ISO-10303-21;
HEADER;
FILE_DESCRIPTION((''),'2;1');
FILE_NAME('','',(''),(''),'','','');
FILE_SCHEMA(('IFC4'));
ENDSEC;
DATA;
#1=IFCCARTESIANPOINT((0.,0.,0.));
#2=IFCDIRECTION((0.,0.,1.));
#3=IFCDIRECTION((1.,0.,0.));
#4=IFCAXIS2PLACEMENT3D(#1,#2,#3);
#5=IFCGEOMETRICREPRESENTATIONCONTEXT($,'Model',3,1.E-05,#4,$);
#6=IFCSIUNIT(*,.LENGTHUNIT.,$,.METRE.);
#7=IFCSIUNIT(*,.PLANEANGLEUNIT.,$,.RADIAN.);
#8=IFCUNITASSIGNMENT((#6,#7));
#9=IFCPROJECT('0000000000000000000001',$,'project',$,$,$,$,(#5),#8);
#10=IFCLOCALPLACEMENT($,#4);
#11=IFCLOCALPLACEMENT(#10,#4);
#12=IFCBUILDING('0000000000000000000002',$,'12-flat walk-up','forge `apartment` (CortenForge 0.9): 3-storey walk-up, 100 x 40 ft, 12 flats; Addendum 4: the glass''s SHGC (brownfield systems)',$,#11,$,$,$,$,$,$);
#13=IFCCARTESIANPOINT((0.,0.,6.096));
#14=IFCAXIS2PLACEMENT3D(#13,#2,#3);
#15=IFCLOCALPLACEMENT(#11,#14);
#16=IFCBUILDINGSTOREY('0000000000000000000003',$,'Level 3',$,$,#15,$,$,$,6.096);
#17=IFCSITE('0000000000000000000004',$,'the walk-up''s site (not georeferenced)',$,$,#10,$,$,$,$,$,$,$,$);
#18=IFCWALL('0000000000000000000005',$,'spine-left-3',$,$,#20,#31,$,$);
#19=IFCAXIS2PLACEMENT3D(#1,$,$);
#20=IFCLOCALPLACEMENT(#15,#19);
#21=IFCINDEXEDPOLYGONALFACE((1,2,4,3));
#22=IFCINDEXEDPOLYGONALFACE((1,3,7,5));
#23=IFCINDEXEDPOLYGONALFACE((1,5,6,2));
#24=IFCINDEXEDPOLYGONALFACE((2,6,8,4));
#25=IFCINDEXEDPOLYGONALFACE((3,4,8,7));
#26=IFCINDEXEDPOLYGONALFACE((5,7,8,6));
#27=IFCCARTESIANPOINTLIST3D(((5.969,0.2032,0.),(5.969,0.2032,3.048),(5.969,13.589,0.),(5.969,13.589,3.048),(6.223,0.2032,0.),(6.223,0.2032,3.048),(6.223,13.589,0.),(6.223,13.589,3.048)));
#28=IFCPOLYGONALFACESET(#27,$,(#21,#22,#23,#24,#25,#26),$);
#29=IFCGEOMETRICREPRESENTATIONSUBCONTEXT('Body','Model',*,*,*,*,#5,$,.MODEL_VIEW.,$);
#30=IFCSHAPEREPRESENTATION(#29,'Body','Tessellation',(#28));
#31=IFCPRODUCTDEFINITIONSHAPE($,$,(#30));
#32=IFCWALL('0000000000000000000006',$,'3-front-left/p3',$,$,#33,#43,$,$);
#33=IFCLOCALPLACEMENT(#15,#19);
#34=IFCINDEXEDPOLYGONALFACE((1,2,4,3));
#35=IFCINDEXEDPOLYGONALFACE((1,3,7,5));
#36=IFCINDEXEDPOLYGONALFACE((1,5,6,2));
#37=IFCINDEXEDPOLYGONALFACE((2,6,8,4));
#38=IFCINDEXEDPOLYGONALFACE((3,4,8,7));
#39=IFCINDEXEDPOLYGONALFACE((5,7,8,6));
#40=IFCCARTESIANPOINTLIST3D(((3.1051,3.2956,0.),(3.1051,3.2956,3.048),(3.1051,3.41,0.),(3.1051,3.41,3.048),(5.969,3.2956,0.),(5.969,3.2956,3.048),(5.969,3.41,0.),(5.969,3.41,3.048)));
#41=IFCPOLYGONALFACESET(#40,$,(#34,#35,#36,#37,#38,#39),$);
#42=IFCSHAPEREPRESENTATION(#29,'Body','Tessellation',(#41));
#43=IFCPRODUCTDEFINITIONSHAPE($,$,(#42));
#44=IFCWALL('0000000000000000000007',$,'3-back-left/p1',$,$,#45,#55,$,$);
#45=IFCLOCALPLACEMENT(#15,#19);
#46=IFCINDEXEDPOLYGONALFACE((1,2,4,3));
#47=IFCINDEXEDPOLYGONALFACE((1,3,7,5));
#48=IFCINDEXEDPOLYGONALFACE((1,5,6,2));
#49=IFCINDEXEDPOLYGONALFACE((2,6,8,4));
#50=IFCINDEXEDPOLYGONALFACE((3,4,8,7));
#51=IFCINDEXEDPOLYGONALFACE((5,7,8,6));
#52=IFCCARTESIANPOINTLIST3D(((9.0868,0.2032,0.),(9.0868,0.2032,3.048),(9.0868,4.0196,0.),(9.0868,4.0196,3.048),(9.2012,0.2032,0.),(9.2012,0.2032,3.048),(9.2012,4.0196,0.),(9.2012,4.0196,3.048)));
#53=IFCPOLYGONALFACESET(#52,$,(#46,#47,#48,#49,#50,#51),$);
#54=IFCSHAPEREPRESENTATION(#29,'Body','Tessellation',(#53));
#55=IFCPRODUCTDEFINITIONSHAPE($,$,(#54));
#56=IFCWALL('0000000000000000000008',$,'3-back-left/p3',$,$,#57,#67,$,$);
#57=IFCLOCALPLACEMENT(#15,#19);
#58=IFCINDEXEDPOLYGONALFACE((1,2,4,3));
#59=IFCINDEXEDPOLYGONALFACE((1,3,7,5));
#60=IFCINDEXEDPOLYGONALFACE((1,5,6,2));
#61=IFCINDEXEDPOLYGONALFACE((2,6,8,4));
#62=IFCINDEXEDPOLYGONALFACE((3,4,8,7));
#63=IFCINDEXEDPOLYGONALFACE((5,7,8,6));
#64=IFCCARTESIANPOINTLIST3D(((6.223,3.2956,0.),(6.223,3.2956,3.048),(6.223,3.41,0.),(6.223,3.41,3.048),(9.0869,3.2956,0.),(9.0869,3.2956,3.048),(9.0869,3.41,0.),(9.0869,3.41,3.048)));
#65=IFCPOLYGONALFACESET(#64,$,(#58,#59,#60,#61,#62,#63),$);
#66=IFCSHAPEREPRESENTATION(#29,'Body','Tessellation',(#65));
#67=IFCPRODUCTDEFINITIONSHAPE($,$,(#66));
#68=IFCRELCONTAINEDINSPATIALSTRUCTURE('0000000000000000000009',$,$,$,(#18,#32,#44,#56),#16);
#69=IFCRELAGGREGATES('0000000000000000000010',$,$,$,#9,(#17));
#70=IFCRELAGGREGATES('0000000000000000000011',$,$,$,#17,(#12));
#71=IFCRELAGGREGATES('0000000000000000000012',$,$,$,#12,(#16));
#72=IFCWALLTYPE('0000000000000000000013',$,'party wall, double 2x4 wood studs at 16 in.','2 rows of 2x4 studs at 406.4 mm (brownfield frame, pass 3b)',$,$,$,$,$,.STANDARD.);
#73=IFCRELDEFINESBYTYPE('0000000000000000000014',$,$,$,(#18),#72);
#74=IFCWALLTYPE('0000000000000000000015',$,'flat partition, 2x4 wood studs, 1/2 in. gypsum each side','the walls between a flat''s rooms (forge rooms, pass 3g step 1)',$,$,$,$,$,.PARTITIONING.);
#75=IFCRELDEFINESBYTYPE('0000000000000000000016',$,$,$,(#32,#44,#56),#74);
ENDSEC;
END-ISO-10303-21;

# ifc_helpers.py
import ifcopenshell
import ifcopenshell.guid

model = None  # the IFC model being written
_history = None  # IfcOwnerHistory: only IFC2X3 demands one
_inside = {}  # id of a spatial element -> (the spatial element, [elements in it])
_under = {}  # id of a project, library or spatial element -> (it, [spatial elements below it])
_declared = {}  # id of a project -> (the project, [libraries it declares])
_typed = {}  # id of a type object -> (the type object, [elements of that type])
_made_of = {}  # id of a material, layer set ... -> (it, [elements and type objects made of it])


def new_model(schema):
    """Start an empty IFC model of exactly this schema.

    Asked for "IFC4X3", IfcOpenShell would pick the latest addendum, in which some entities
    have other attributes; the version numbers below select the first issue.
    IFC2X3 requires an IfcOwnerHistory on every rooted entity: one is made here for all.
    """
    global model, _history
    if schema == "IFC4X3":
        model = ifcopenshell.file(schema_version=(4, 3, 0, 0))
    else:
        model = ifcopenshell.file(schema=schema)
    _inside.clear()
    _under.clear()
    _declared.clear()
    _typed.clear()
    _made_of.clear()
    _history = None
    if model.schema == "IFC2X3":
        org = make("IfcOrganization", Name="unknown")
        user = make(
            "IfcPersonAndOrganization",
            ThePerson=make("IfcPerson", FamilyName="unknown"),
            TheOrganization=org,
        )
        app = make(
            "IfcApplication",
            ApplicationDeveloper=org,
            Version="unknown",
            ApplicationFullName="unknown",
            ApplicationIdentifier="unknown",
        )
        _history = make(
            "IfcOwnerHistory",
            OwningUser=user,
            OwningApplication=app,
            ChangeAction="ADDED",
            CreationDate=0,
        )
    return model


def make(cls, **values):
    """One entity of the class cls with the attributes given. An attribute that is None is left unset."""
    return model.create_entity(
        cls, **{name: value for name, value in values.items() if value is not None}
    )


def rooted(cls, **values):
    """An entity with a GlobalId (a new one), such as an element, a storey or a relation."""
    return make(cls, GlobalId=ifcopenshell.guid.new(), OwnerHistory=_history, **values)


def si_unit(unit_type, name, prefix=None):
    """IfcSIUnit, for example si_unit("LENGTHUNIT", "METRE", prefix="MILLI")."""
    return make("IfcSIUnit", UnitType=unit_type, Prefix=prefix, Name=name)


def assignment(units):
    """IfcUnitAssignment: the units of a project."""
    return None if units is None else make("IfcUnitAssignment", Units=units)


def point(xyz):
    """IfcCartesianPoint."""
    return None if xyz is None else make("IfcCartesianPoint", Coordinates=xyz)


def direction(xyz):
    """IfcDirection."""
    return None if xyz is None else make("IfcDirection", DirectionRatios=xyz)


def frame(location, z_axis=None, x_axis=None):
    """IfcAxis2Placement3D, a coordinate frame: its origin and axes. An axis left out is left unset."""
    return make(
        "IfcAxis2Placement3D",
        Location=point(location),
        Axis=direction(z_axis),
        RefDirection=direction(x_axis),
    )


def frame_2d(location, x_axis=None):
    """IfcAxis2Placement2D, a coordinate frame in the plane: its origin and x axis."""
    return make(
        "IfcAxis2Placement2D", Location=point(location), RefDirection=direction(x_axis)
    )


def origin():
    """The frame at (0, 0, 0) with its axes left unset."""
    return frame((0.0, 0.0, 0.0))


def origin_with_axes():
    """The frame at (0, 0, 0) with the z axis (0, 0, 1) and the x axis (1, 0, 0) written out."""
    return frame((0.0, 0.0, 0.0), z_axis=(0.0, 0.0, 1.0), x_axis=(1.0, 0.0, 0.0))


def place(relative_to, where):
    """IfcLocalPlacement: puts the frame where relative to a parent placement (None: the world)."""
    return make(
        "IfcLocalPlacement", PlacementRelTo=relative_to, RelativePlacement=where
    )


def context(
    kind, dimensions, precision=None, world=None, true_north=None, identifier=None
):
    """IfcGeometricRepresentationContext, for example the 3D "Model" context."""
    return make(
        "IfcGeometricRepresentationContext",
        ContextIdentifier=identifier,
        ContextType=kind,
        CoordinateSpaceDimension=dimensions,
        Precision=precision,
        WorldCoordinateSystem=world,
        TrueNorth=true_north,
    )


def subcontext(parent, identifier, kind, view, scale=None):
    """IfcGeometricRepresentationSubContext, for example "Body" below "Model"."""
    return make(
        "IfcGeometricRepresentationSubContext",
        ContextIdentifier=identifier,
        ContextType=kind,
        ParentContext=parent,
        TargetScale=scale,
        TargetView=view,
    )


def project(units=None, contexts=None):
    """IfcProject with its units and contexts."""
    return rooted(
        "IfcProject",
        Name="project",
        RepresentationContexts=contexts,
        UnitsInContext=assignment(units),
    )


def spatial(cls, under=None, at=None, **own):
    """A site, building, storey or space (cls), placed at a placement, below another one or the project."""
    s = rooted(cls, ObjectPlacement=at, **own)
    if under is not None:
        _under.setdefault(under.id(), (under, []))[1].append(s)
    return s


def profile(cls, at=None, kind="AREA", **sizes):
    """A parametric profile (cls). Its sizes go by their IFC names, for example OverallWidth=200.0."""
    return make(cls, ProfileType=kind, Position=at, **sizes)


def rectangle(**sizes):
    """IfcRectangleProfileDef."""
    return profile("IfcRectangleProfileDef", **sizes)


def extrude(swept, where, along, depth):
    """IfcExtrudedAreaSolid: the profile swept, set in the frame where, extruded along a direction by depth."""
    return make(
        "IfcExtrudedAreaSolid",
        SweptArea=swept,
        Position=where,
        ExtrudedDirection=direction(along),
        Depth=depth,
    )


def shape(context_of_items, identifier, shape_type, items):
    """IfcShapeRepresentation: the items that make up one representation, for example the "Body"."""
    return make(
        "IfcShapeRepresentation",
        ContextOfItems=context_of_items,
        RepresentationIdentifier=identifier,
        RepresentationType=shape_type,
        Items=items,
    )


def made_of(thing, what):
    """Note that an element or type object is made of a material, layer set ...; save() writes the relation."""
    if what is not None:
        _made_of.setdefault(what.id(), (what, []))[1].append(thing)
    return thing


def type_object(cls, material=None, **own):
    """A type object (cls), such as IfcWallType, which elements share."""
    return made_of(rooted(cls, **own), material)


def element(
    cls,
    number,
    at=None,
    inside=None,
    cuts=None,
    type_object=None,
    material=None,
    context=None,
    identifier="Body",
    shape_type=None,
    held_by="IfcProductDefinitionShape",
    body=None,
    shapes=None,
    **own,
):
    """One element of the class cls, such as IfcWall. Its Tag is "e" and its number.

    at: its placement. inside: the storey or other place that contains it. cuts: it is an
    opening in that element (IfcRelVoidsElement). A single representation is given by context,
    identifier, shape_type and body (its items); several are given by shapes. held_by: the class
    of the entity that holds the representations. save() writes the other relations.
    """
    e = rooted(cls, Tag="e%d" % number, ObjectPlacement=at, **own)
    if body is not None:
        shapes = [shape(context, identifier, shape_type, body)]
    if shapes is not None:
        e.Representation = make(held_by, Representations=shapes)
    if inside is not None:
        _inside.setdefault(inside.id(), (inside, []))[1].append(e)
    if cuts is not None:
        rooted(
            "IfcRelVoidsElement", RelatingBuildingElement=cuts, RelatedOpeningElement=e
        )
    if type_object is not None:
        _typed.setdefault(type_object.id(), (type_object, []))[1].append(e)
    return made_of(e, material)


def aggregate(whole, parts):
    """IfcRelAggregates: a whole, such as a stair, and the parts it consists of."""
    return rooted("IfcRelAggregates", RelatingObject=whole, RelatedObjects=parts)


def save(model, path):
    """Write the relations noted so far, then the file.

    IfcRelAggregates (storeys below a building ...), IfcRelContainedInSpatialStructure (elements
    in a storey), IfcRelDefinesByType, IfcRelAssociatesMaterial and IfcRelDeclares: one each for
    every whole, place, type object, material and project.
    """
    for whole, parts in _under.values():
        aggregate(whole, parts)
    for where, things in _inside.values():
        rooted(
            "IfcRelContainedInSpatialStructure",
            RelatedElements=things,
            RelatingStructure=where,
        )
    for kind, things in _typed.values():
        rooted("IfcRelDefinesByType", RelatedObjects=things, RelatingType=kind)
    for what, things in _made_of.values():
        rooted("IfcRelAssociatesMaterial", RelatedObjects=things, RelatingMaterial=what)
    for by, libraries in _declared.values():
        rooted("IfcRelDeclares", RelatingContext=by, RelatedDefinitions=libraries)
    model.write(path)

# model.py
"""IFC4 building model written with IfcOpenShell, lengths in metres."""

from ifc_helpers import new_model, si_unit, frame, frame_2d, origin, origin_with_axes, place, context, subcontext, project, spatial, rectangle, extrude, type_object, element, save


model = new_model("IFC4")

# Units and contexts
model_context = context("Model", 3, precision=1e-05, world=origin_with_axes())
body_context = subcontext(model_context, "Body", "Model", "MODEL_VIEW")
ifc_project = project(units=[si_unit("LENGTHUNIT", "METRE"), si_unit("PLANEANGLEUNIT", "RADIAN")], contexts=[model_context])

# Site, building, storey
site_placement = place(None, origin_with_axes())
site = spatial("IfcSite", under=ifc_project, at=site_placement, Name="the walk-up's site (not georeferenced)")
building_placement = place(site_placement, origin_with_axes())
building = spatial("IfcBuilding", under=site, at=building_placement, Name="12-flat walk-up", Description="forge `apartment` (CortenForge 0.9): 3-storey walk-up, 100 x 40 ft, 12 flats; Addendum 4: the glass's SHGC (brownfield systems)")
storey_placement = place(building_placement, frame((0.0, 0.0, 6.096), z_axis=(0.0, 0.0, 1.0), x_axis=(1.0, 0.0, 0.0)))
storey = spatial("IfcBuildingStorey", under=building, at=storey_placement, Name="Level 3", Elevation=6.096)

# Walls
wall_type_1 = type_object("IfcWallType", Name="party wall, double 2x4 wood studs at 16 in.", Description="2 rows of 2x4 studs at 406.4 mm (brownfield frame, pass 3b)", PredefinedType="STANDARD")
wall_1_placement = place(storey_placement, frame((5.969, 0.2032, 0.0), z_axis=(0.0, 0.0, 1.0), x_axis=(1.0, 0.0, 0.0)))
element("IfcWall", 1, at=wall_1_placement, inside=storey, type_object=wall_type_1, Name="spine-left-3", context=body_context, shape_type="SweptSolid", body=[
    extrude(rectangle(XDim=0.254, YDim=13.3858, at=frame_2d((0.127, 6.6929))), origin(), (0.0, 0.0, 1.0), 3.048),
])
wall_type_2 = type_object("IfcWallType", Name="flat partition, 2x4 wood studs, 1/2 in. gypsum each side", Description="the walls between a flat's rooms (forge rooms, pass 3g step 1)", PredefinedType="PARTITIONING")
wall_2_placement = place(storey_placement, frame((3.1051, 3.2957, 0.0), z_axis=(0.0, 0.0, 1.0), x_axis=(1.0, 0.0, 0.0)))
element("IfcWall", 2, at=wall_2_placement, inside=storey, type_object=wall_type_2, Name="3-front-left/p3", context=body_context, shape_type="SweptSolid", body=[
    extrude(rectangle(XDim=2.8639, YDim=0.1143, at=frame_2d((1.4319, 0.0571))), origin(), (0.0, 0.0, 1.0), 3.048),
])
wall_3_placement = place(storey_placement, frame((9.0869, 0.2032, 0.0), z_axis=(0.0, 0.0, 1.0), x_axis=(1.0, 0.0, 0.0)))
element("IfcWall", 3, at=wall_3_placement, inside=storey, type_object=wall_type_2, Name="3-back-left/p1", context=body_context, shape_type="SweptSolid", body=[
    extrude(rectangle(XDim=0.1143, YDim=3.8163, at=frame_2d((0.0572, 1.9082))), origin(), (0.0, 0.0, 1.0), 3.048),
])
wall_4_placement = place(storey_placement, frame((6.223, 3.2957, 0.0), z_axis=(0.0, 0.0, 1.0), x_axis=(1.0, 0.0, 0.0)))
element("IfcWall", 4, at=wall_4_placement, inside=storey, type_object=wall_type_2, Name="3-back-left/p3", context=body_context, shape_type="SweptSolid", body=[
    extrude(rectangle(XDim=2.8639, YDim=0.1143, at=frame_2d((1.4319, 0.0571))), origin(), (0.0, 0.0, 1.0), 3.048),
])

save(model, "model.ifc")
